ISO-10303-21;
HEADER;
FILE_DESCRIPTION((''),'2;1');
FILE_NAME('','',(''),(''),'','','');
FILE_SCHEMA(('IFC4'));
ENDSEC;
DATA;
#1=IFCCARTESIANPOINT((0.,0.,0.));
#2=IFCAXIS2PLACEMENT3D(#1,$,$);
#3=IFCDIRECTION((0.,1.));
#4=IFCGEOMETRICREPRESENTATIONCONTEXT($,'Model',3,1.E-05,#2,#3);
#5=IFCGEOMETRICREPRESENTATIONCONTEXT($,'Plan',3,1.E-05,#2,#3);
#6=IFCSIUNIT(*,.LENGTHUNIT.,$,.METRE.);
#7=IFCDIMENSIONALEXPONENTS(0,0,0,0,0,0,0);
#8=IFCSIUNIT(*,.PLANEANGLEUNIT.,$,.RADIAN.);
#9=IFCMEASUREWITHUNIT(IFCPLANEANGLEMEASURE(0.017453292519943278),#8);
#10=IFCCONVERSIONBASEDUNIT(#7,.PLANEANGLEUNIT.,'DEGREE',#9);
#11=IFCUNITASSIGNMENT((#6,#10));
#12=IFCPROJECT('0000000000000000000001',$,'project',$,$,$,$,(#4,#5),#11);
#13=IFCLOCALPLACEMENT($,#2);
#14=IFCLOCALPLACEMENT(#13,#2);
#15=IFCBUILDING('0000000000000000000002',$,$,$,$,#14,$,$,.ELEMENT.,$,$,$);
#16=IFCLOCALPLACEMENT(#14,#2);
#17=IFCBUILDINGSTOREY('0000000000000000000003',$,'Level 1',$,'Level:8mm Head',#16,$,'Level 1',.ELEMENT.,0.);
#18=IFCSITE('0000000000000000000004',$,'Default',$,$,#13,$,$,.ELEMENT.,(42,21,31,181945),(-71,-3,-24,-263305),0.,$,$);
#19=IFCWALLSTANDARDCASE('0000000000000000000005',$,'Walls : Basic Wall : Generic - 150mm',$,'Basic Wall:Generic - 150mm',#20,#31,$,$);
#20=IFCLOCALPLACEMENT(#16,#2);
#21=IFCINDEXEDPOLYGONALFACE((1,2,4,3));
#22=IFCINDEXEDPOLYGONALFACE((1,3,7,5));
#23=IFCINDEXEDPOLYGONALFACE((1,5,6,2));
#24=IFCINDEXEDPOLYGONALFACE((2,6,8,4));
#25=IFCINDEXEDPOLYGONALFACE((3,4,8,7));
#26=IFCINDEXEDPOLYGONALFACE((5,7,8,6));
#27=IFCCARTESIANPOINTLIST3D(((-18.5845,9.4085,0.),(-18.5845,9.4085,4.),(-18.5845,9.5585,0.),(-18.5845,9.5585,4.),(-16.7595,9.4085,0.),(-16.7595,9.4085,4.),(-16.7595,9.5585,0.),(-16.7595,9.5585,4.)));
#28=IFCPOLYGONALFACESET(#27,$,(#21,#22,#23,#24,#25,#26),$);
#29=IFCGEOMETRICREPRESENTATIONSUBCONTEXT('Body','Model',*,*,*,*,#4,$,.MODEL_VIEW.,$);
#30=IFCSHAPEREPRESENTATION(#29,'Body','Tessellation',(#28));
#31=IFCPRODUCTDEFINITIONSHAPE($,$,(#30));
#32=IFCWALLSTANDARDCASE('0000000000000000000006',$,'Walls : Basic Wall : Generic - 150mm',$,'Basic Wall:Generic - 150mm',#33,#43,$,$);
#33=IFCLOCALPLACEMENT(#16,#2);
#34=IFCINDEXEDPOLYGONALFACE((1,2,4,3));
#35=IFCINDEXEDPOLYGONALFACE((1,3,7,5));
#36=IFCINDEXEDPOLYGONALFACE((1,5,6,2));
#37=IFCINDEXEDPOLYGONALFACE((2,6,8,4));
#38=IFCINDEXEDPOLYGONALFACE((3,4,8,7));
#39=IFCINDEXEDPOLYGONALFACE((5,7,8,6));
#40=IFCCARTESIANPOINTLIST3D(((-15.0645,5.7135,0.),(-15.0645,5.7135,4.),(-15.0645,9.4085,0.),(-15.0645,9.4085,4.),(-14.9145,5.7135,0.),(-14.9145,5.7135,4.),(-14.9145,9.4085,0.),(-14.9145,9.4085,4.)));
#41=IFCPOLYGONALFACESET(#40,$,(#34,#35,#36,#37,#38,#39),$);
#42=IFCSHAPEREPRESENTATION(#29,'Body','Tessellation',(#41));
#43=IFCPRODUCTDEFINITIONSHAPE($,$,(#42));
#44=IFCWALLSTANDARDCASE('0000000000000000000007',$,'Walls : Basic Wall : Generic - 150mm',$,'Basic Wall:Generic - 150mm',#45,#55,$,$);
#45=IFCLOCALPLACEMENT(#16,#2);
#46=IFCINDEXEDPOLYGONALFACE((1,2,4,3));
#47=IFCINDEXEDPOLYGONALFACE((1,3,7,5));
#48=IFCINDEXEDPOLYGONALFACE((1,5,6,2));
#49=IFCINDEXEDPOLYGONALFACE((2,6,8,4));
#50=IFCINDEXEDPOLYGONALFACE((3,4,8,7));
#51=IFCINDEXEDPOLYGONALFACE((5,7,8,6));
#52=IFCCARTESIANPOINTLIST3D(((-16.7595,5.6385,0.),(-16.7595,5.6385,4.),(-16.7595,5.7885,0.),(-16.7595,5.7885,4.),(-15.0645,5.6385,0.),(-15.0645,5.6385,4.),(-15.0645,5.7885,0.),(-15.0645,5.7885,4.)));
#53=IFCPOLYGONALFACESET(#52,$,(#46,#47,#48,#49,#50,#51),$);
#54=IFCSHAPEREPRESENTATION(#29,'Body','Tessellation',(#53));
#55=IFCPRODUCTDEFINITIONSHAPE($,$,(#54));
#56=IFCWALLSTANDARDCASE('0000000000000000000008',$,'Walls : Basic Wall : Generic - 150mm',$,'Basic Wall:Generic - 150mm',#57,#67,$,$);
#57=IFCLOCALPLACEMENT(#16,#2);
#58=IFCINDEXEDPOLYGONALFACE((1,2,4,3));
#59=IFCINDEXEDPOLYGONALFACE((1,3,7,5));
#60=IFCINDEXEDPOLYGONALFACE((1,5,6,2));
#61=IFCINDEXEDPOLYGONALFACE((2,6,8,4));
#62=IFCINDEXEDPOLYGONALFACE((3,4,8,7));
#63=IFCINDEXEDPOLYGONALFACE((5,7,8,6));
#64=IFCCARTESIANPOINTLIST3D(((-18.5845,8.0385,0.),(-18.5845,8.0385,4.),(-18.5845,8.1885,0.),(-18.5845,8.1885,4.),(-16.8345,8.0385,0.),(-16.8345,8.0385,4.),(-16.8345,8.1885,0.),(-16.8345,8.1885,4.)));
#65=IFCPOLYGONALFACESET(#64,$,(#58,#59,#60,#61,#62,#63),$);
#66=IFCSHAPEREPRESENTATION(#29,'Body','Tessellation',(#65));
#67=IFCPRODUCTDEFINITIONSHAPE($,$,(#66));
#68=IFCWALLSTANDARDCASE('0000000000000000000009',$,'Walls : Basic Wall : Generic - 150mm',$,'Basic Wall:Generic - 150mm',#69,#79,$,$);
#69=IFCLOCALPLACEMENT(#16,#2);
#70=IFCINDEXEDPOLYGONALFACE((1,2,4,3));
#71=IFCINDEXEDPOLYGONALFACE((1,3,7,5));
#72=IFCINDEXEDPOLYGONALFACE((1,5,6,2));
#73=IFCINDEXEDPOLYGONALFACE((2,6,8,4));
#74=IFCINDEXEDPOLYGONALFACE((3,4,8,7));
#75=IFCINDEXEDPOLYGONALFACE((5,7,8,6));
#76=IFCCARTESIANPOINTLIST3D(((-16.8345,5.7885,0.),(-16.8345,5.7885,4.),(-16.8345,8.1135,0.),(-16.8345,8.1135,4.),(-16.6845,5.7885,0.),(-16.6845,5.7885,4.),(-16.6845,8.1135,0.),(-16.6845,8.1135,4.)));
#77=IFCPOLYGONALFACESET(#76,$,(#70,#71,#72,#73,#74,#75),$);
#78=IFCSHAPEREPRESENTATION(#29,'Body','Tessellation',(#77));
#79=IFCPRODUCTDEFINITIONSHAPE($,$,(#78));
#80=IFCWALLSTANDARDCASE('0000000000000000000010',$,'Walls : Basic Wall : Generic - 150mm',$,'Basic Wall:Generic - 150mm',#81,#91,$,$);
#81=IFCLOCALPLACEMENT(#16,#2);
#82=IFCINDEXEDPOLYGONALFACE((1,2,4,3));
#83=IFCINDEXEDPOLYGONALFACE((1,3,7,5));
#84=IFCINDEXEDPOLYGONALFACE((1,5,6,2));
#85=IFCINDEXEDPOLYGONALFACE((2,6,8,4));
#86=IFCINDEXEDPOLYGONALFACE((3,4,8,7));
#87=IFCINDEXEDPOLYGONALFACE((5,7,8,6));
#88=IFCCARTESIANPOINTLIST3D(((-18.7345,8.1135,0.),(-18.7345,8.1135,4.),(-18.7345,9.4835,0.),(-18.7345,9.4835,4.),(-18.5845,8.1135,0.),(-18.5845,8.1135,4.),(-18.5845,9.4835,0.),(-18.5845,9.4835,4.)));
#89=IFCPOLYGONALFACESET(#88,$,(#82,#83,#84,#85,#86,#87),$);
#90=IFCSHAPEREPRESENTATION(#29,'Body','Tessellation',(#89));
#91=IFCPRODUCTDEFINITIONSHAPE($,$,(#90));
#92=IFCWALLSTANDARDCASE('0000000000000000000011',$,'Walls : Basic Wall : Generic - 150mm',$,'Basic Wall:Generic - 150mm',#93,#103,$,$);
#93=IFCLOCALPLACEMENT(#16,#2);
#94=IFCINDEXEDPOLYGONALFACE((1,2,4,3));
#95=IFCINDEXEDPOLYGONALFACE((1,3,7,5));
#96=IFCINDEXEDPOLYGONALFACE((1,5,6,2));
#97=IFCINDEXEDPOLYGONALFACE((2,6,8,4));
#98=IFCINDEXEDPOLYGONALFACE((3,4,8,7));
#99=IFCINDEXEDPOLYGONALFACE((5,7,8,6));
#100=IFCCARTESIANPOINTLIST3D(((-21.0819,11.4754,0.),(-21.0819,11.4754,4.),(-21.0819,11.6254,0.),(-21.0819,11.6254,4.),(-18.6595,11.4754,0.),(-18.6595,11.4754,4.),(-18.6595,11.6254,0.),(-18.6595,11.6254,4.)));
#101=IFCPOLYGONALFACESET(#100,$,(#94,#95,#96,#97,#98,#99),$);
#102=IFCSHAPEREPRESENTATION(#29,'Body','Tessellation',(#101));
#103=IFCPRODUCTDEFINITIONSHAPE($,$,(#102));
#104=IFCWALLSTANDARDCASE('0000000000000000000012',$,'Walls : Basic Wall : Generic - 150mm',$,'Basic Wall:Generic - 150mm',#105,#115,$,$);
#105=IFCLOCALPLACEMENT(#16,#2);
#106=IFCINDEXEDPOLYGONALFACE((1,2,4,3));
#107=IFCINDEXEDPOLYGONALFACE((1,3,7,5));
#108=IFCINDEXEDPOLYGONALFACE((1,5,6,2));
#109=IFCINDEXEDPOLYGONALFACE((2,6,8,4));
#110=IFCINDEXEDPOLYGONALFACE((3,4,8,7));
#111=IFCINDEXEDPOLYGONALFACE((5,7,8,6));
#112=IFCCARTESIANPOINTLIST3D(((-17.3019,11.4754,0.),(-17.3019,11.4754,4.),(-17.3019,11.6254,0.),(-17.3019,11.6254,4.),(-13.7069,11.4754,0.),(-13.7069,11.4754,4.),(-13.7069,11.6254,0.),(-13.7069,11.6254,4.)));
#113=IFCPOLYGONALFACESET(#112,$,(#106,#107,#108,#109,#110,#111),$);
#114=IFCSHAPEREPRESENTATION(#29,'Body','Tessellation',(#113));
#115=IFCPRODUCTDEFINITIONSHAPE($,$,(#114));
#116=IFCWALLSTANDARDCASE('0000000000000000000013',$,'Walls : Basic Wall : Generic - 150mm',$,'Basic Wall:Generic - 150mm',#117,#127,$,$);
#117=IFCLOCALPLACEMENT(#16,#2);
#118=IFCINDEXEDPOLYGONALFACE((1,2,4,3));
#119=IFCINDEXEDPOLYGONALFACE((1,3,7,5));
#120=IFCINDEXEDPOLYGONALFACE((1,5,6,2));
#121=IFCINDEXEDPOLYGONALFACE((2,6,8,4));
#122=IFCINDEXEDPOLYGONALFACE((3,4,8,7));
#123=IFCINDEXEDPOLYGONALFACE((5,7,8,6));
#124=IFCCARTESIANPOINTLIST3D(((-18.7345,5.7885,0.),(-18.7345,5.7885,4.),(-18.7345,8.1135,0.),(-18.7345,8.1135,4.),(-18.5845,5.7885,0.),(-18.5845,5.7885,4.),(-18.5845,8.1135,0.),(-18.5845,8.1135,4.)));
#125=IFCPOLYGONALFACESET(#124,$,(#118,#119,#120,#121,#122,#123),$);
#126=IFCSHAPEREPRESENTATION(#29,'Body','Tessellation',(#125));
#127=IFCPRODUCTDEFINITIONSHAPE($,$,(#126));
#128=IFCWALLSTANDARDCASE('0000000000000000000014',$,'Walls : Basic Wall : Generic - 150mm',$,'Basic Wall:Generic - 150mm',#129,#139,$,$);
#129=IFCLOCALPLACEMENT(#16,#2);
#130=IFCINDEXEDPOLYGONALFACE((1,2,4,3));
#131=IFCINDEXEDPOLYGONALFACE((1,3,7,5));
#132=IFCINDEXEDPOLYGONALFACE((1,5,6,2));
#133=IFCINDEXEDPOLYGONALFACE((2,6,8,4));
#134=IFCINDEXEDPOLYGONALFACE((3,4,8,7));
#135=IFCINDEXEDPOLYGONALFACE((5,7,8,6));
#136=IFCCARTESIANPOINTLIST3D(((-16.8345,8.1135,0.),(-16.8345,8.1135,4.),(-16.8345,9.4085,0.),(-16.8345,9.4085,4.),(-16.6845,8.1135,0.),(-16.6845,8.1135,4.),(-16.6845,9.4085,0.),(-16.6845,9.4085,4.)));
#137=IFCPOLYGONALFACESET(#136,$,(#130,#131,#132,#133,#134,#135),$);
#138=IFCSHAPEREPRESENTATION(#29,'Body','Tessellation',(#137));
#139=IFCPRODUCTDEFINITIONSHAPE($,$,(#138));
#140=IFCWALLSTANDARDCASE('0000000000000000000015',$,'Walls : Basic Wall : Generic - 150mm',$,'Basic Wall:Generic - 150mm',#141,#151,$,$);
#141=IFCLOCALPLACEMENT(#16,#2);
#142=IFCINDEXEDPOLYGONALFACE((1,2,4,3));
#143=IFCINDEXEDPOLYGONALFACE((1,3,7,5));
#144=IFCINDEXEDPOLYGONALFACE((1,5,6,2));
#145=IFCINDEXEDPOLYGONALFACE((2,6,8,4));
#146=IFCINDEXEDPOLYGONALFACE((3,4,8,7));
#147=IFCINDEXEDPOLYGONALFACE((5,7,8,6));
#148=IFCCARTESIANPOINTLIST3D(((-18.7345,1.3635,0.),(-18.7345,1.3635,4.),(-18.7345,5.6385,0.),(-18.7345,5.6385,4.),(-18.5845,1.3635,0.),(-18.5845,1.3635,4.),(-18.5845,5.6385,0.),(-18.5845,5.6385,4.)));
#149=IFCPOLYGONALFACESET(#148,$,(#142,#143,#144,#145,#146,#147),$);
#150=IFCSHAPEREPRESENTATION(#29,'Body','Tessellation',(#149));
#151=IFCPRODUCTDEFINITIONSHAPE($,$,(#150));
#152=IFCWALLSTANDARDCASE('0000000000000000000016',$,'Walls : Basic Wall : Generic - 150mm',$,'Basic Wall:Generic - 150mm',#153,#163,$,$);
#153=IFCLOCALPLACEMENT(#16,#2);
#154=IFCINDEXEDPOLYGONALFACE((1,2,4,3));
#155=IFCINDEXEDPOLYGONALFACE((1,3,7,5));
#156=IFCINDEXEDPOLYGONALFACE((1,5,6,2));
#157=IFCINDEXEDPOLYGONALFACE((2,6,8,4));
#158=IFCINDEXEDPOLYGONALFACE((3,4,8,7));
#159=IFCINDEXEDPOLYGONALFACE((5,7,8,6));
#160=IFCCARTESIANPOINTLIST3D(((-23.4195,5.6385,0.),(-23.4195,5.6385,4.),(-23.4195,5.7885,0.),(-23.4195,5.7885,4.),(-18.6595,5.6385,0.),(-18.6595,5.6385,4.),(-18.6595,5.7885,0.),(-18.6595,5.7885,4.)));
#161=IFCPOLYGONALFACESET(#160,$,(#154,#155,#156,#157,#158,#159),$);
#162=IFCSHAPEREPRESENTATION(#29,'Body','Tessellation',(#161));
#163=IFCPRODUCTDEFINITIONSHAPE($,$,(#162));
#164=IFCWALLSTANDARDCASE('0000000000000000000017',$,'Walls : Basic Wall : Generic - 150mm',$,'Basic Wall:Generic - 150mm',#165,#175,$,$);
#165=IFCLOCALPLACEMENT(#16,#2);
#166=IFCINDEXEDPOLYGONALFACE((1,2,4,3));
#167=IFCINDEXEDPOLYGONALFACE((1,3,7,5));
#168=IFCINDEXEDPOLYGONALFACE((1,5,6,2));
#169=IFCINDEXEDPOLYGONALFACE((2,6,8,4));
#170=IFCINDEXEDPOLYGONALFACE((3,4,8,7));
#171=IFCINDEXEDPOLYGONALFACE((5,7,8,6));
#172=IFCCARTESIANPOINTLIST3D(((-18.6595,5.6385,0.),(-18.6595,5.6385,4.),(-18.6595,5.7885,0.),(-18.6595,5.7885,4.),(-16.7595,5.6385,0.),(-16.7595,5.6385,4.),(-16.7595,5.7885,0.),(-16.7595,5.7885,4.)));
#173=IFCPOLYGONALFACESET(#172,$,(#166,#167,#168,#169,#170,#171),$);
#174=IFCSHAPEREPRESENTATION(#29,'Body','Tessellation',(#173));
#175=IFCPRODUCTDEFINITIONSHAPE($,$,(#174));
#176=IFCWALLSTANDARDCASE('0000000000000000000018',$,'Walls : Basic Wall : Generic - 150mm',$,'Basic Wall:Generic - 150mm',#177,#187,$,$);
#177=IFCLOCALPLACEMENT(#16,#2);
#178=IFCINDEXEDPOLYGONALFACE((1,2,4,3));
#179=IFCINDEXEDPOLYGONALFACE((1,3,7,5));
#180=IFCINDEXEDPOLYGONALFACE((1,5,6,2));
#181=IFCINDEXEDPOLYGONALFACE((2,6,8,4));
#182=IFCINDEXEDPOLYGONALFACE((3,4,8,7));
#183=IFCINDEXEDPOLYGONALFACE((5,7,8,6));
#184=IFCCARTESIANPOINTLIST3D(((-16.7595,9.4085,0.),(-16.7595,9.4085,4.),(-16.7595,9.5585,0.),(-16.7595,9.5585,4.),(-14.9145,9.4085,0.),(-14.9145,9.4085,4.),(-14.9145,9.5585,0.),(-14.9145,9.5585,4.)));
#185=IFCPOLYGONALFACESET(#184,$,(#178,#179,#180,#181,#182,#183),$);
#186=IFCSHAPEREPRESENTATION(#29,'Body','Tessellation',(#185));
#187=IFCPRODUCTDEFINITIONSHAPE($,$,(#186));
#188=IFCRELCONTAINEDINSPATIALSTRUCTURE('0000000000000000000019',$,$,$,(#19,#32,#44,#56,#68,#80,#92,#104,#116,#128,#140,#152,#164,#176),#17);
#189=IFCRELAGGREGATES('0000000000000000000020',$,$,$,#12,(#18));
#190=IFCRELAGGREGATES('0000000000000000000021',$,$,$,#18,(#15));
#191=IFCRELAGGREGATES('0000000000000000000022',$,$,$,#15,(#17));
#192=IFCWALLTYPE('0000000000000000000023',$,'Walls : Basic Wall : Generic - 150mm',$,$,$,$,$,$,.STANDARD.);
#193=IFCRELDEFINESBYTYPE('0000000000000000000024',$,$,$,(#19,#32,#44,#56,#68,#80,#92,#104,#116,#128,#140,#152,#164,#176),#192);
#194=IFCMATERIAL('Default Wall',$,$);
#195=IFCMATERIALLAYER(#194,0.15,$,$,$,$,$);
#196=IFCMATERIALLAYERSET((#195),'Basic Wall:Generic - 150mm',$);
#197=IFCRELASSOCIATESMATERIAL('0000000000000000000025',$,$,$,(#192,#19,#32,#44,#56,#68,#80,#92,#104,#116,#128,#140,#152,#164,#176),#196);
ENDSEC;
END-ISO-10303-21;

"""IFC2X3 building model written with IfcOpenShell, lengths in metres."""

from ifc_helpers import new_model, entity, si_unit, converted_unit, direction, frame, frame_2d, origin, place, context, subcontext, project, spatial, rectangle, extrude, material, layer, layer_set, layer_usage, type_object, element, save


model = new_model("IFC2X3")

# Units and contexts
model_context = context("Model", 3, precision=1e-05, world=origin(), true_north=direction((0.0, 1.0)))
plan_context = context("Plan", 3, precision=1e-05, world=origin(), true_north=direction((0.0, 1.0)))
body_context = subcontext(model_context, "Body", "Model", "MODEL_VIEW")
ifc_project = project(units=[si_unit("LENGTHUNIT", "METRE"), converted_unit("PLANEANGLEUNIT", "DEGREE", entity("IfcPlaneAngleMeasure", 0.017453292519943278), si_unit("PLANEANGLEUNIT", "RADIAN"), dimensions=[0, 0, 0, 0, 0, 0, 0])], contexts=[model_context, plan_context])

# Site, building, storey
site_placement = place(None, origin())
site = spatial("IfcSite", under=ifc_project, at=site_placement, Name="Default", CompositionType="ELEMENT", RefLatitude=(42, 21, 31, 181945), RefLongitude=(-71, -3, -24, -263305), RefElevation=0.0)
building_placement = place(site_placement, origin())
building = spatial("IfcBuilding", under=site, at=building_placement, CompositionType="ELEMENT")
storey_placement = place(building_placement, origin())
storey = spatial("IfcBuildingStorey", under=building, at=storey_placement, Name="Level 1", ObjectType="Level:8mm Head", LongName="Level 1", CompositionType="ELEMENT", Elevation=0.0)

# Walls
ifc_material = material(Name="Default Wall")
ifc_layer_1 = layer(ifc_material, 0.15)
ifc_layer_set_1 = layer_set([ifc_layer_1], Name="Basic Wall:Generic - 150mm")
ifc_layer_usage_1 = layer_usage(ifc_layer_set_1, "AXIS2", "NEGATIVE", 0.075)
wall_type_1 = type_object("IfcWallType", Name="Walls : Basic Wall : Generic - 150mm", PredefinedType="STANDARD", material=ifc_layer_set_1)
wall_1_placement = place(storey_placement, frame((-18.5845, 9.4835, 0.0)))
element("IfcWallStandardCase", 1, at=wall_1_placement, inside=storey, type_object=wall_type_1, material=ifc_layer_usage_1, Name="Walls : Basic Wall : Generic - 150mm", ObjectType="Basic Wall:Generic - 150mm", context=body_context, shape_type="SweptSolid", body=[
    extrude(rectangle(XDim=1.825, YDim=0.15, at=frame_2d((0.9125, 0.0), x_axis=(-1.0, 0.0))), origin(), (0.0, 0.0, 1.0), 4.0),
])
wall_2_placement = place(storey_placement, frame((-14.9895, 9.4085, 0.0), z_axis=(0.0, 0.0, 1.0), x_axis=(0.0, -1.0, 0.0)))
element("IfcWallStandardCase", 2, at=wall_2_placement, inside=storey, type_object=wall_type_1, material=ifc_layer_usage_1, Name="Walls : Basic Wall : Generic - 150mm", ObjectType="Basic Wall:Generic - 150mm", context=body_context, shape_type="SweptSolid", body=[
    extrude(rectangle(XDim=3.695, YDim=0.15, at=frame_2d((1.8475, 0.0), x_axis=(-1.0, 0.0))), origin(), (0.0, 0.0, 1.0), 4.0),
])
wall_3_placement = place(storey_placement, frame((-15.0645, 5.7135, 0.0), z_axis=(0.0, 0.0, 1.0), x_axis=(-1.0, 0.0, 0.0)))
element("IfcWallStandardCase", 3, at=wall_3_placement, inside=storey, type_object=wall_type_1, material=ifc_layer_usage_1, Name="Walls : Basic Wall : Generic - 150mm", ObjectType="Basic Wall:Generic - 150mm", context=body_context, shape_type="SweptSolid", body=[
    extrude(rectangle(XDim=1.695, YDim=0.15, at=frame_2d((0.8475, 0.0), x_axis=(-1.0, 0.0))), origin(), (0.0, 0.0, 1.0), 4.0),
])
wall_4_placement = place(storey_placement, frame((-18.5845, 8.1135, 0.0)))
element("IfcWallStandardCase", 4, at=wall_4_placement, inside=storey, type_object=wall_type_1, material=ifc_layer_usage_1, Name="Walls : Basic Wall : Generic - 150mm", ObjectType="Basic Wall:Generic - 150mm", context=body_context, shape_type="SweptSolid", body=[
    extrude(rectangle(XDim=1.75, YDim=0.15, at=frame_2d((0.875, 0.0), x_axis=(-1.0, 0.0))), origin(), (0.0, 0.0, 1.0), 4.0),
])
wall_5_placement = place(storey_placement, frame((-16.7595, 5.7885, 0.0), z_axis=(0.0, 0.0, 1.0), x_axis=(0.0, 1.0, 0.0)))
element("IfcWallStandardCase", 5, at=wall_5_placement, inside=storey, type_object=wall_type_1, material=ifc_layer_usage_1, Name="Walls : Basic Wall : Generic - 150mm", ObjectType="Basic Wall:Generic - 150mm", context=body_context, shape_type="SweptSolid", body=[
    extrude(rectangle(XDim=2.325, YDim=0.15, at=frame_2d((1.1625, 0.0), x_axis=(-1.0, 0.0))), origin(), (0.0, 0.0, 1.0), 4.0),
])
wall_6_placement = place(storey_placement, frame((-18.6595, 9.4835, 0.0), z_axis=(0.0, 0.0, 1.0), x_axis=(0.0, -1.0, 0.0)))
element("IfcWallStandardCase", 6, at=wall_6_placement, inside=storey, type_object=wall_type_1, material=ifc_layer_usage_1, Name="Walls : Basic Wall : Generic - 150mm", ObjectType="Basic Wall:Generic - 150mm", context=body_context, shape_type="SweptSolid", body=[
    extrude(rectangle(XDim=1.37, YDim=0.15, at=frame_2d((0.685, 0.0), x_axis=(-1.0, 0.0))), origin(), (0.0, 0.0, 1.0), 4.0),
])
wall_7_placement = place(storey_placement, frame((-21.0819, 11.5504, 0.0)))
element("IfcWallStandardCase", 7, at=wall_7_placement, inside=storey, type_object=wall_type_1, material=ifc_layer_usage_1, Name="Walls : Basic Wall : Generic - 150mm", ObjectType="Basic Wall:Generic - 150mm", context=body_context, shape_type="SweptSolid", body=[
    extrude(rectangle(XDim=2.4224, YDim=0.15, at=frame_2d((1.2112, 0.0), x_axis=(-1.0, 0.0))), origin(), (0.0, 0.0, 1.0), 4.0),
])
wall_8_placement = place(storey_placement, frame((-17.3019, 11.5504, 0.0)))
element("IfcWallStandardCase", 8, at=wall_8_placement, inside=storey, type_object=wall_type_1, material=ifc_layer_usage_1, Name="Walls : Basic Wall : Generic - 150mm", ObjectType="Basic Wall:Generic - 150mm", context=body_context, shape_type="SweptSolid", body=[
    extrude(rectangle(XDim=3.595, YDim=0.15, at=frame_2d((1.7975, 0.0), x_axis=(-1.0, 0.0))), origin(), (0.0, 0.0, 1.0), 4.0),
])
wall_9_placement = place(storey_placement, frame((-18.6595, 8.1135, 0.0), z_axis=(0.0, 0.0, 1.0), x_axis=(0.0, -1.0, 0.0)))
element("IfcWallStandardCase", 9, at=wall_9_placement, inside=storey, type_object=wall_type_1, material=ifc_layer_usage_1, Name="Walls : Basic Wall : Generic - 150mm", ObjectType="Basic Wall:Generic - 150mm", context=body_context, shape_type="SweptSolid", body=[
    extrude(rectangle(XDim=2.325, YDim=0.15, at=frame_2d((1.1625, 0.0), x_axis=(-1.0, 0.0))), origin(), (0.0, 0.0, 1.0), 4.0),
])
wall_10_placement = place(storey_placement, frame((-16.7595, 8.1135, 0.0), z_axis=(0.0, 0.0, 1.0), x_axis=(0.0, 1.0, 0.0)))
element("IfcWallStandardCase", 10, at=wall_10_placement, inside=storey, type_object=wall_type_1, material=ifc_layer_usage_1, Name="Walls : Basic Wall : Generic - 150mm", ObjectType="Basic Wall:Generic - 150mm", context=body_context, shape_type="SweptSolid", body=[
    extrude(rectangle(XDim=1.295, YDim=0.15, at=frame_2d((0.6475, 0.0), x_axis=(-1.0, 0.0))), origin(), (0.0, 0.0, 1.0), 4.0),
])
wall_11_placement = place(storey_placement, frame((-18.6595, 5.6385, 0.0), z_axis=(0.0, 0.0, 1.0), x_axis=(0.0, -1.0, 0.0)))
element("IfcWallStandardCase", 11, at=wall_11_placement, inside=storey, type_object=wall_type_1, material=ifc_layer_usage_1, Name="Walls : Basic Wall : Generic - 150mm", ObjectType="Basic Wall:Generic - 150mm", context=body_context, shape_type="SweptSolid", body=[
    extrude(rectangle(XDim=4.275, YDim=0.15, at=frame_2d((2.1375, 0.0), x_axis=(-1.0, 0.0))), origin(), (0.0, 0.0, 1.0), 4.0),
])
wall_12_placement = place(storey_placement, frame((-18.6595, 5.7135, 0.0), z_axis=(0.0, 0.0, 1.0), x_axis=(-1.0, 0.0, 0.0)))
element("IfcWallStandardCase", 12, at=wall_12_placement, inside=storey, type_object=wall_type_1, material=ifc_layer_usage_1, Name="Walls : Basic Wall : Generic - 150mm", ObjectType="Basic Wall:Generic - 150mm", context=body_context, shape_type="SweptSolid", body=[
    extrude(rectangle(XDim=4.76, YDim=0.15, at=frame_2d((2.38, 0.0), x_axis=(-1.0, 0.0))), origin(), (0.0, 0.0, 1.0), 4.0),
])
wall_13_placement = place(storey_placement, frame((-16.7595, 5.7135, 0.0), z_axis=(0.0, 0.0, 1.0), x_axis=(-1.0, 0.0, 0.0)))
element("IfcWallStandardCase", 13, at=wall_13_placement, inside=storey, type_object=wall_type_1, material=ifc_layer_usage_1, Name="Walls : Basic Wall : Generic - 150mm", ObjectType="Basic Wall:Generic - 150mm", context=body_context, shape_type="SweptSolid", body=[
    extrude(rectangle(XDim=1.9, YDim=0.15, at=frame_2d((0.95, 0.0), x_axis=(-1.0, 0.0))), origin(), (0.0, 0.0, 1.0), 4.0),
])
wall_14_placement = place(storey_placement, frame((-16.7595, 9.4835, 0.0)))
element("IfcWallStandardCase", 14, at=wall_14_placement, inside=storey, type_object=wall_type_1, material=ifc_layer_usage_1, Name="Walls : Basic Wall : Generic - 150mm", ObjectType="Basic Wall:Generic - 150mm", context=body_context, shape_type="SweptSolid", body=[
    extrude(rectangle(XDim=1.845, YDim=0.15, at=frame_2d((0.9225, 0.0), x_axis=(-1.0, 0.0))), origin(), (0.0, 0.0, 1.0), 4.0),
])

save(model, "model.ifc")
